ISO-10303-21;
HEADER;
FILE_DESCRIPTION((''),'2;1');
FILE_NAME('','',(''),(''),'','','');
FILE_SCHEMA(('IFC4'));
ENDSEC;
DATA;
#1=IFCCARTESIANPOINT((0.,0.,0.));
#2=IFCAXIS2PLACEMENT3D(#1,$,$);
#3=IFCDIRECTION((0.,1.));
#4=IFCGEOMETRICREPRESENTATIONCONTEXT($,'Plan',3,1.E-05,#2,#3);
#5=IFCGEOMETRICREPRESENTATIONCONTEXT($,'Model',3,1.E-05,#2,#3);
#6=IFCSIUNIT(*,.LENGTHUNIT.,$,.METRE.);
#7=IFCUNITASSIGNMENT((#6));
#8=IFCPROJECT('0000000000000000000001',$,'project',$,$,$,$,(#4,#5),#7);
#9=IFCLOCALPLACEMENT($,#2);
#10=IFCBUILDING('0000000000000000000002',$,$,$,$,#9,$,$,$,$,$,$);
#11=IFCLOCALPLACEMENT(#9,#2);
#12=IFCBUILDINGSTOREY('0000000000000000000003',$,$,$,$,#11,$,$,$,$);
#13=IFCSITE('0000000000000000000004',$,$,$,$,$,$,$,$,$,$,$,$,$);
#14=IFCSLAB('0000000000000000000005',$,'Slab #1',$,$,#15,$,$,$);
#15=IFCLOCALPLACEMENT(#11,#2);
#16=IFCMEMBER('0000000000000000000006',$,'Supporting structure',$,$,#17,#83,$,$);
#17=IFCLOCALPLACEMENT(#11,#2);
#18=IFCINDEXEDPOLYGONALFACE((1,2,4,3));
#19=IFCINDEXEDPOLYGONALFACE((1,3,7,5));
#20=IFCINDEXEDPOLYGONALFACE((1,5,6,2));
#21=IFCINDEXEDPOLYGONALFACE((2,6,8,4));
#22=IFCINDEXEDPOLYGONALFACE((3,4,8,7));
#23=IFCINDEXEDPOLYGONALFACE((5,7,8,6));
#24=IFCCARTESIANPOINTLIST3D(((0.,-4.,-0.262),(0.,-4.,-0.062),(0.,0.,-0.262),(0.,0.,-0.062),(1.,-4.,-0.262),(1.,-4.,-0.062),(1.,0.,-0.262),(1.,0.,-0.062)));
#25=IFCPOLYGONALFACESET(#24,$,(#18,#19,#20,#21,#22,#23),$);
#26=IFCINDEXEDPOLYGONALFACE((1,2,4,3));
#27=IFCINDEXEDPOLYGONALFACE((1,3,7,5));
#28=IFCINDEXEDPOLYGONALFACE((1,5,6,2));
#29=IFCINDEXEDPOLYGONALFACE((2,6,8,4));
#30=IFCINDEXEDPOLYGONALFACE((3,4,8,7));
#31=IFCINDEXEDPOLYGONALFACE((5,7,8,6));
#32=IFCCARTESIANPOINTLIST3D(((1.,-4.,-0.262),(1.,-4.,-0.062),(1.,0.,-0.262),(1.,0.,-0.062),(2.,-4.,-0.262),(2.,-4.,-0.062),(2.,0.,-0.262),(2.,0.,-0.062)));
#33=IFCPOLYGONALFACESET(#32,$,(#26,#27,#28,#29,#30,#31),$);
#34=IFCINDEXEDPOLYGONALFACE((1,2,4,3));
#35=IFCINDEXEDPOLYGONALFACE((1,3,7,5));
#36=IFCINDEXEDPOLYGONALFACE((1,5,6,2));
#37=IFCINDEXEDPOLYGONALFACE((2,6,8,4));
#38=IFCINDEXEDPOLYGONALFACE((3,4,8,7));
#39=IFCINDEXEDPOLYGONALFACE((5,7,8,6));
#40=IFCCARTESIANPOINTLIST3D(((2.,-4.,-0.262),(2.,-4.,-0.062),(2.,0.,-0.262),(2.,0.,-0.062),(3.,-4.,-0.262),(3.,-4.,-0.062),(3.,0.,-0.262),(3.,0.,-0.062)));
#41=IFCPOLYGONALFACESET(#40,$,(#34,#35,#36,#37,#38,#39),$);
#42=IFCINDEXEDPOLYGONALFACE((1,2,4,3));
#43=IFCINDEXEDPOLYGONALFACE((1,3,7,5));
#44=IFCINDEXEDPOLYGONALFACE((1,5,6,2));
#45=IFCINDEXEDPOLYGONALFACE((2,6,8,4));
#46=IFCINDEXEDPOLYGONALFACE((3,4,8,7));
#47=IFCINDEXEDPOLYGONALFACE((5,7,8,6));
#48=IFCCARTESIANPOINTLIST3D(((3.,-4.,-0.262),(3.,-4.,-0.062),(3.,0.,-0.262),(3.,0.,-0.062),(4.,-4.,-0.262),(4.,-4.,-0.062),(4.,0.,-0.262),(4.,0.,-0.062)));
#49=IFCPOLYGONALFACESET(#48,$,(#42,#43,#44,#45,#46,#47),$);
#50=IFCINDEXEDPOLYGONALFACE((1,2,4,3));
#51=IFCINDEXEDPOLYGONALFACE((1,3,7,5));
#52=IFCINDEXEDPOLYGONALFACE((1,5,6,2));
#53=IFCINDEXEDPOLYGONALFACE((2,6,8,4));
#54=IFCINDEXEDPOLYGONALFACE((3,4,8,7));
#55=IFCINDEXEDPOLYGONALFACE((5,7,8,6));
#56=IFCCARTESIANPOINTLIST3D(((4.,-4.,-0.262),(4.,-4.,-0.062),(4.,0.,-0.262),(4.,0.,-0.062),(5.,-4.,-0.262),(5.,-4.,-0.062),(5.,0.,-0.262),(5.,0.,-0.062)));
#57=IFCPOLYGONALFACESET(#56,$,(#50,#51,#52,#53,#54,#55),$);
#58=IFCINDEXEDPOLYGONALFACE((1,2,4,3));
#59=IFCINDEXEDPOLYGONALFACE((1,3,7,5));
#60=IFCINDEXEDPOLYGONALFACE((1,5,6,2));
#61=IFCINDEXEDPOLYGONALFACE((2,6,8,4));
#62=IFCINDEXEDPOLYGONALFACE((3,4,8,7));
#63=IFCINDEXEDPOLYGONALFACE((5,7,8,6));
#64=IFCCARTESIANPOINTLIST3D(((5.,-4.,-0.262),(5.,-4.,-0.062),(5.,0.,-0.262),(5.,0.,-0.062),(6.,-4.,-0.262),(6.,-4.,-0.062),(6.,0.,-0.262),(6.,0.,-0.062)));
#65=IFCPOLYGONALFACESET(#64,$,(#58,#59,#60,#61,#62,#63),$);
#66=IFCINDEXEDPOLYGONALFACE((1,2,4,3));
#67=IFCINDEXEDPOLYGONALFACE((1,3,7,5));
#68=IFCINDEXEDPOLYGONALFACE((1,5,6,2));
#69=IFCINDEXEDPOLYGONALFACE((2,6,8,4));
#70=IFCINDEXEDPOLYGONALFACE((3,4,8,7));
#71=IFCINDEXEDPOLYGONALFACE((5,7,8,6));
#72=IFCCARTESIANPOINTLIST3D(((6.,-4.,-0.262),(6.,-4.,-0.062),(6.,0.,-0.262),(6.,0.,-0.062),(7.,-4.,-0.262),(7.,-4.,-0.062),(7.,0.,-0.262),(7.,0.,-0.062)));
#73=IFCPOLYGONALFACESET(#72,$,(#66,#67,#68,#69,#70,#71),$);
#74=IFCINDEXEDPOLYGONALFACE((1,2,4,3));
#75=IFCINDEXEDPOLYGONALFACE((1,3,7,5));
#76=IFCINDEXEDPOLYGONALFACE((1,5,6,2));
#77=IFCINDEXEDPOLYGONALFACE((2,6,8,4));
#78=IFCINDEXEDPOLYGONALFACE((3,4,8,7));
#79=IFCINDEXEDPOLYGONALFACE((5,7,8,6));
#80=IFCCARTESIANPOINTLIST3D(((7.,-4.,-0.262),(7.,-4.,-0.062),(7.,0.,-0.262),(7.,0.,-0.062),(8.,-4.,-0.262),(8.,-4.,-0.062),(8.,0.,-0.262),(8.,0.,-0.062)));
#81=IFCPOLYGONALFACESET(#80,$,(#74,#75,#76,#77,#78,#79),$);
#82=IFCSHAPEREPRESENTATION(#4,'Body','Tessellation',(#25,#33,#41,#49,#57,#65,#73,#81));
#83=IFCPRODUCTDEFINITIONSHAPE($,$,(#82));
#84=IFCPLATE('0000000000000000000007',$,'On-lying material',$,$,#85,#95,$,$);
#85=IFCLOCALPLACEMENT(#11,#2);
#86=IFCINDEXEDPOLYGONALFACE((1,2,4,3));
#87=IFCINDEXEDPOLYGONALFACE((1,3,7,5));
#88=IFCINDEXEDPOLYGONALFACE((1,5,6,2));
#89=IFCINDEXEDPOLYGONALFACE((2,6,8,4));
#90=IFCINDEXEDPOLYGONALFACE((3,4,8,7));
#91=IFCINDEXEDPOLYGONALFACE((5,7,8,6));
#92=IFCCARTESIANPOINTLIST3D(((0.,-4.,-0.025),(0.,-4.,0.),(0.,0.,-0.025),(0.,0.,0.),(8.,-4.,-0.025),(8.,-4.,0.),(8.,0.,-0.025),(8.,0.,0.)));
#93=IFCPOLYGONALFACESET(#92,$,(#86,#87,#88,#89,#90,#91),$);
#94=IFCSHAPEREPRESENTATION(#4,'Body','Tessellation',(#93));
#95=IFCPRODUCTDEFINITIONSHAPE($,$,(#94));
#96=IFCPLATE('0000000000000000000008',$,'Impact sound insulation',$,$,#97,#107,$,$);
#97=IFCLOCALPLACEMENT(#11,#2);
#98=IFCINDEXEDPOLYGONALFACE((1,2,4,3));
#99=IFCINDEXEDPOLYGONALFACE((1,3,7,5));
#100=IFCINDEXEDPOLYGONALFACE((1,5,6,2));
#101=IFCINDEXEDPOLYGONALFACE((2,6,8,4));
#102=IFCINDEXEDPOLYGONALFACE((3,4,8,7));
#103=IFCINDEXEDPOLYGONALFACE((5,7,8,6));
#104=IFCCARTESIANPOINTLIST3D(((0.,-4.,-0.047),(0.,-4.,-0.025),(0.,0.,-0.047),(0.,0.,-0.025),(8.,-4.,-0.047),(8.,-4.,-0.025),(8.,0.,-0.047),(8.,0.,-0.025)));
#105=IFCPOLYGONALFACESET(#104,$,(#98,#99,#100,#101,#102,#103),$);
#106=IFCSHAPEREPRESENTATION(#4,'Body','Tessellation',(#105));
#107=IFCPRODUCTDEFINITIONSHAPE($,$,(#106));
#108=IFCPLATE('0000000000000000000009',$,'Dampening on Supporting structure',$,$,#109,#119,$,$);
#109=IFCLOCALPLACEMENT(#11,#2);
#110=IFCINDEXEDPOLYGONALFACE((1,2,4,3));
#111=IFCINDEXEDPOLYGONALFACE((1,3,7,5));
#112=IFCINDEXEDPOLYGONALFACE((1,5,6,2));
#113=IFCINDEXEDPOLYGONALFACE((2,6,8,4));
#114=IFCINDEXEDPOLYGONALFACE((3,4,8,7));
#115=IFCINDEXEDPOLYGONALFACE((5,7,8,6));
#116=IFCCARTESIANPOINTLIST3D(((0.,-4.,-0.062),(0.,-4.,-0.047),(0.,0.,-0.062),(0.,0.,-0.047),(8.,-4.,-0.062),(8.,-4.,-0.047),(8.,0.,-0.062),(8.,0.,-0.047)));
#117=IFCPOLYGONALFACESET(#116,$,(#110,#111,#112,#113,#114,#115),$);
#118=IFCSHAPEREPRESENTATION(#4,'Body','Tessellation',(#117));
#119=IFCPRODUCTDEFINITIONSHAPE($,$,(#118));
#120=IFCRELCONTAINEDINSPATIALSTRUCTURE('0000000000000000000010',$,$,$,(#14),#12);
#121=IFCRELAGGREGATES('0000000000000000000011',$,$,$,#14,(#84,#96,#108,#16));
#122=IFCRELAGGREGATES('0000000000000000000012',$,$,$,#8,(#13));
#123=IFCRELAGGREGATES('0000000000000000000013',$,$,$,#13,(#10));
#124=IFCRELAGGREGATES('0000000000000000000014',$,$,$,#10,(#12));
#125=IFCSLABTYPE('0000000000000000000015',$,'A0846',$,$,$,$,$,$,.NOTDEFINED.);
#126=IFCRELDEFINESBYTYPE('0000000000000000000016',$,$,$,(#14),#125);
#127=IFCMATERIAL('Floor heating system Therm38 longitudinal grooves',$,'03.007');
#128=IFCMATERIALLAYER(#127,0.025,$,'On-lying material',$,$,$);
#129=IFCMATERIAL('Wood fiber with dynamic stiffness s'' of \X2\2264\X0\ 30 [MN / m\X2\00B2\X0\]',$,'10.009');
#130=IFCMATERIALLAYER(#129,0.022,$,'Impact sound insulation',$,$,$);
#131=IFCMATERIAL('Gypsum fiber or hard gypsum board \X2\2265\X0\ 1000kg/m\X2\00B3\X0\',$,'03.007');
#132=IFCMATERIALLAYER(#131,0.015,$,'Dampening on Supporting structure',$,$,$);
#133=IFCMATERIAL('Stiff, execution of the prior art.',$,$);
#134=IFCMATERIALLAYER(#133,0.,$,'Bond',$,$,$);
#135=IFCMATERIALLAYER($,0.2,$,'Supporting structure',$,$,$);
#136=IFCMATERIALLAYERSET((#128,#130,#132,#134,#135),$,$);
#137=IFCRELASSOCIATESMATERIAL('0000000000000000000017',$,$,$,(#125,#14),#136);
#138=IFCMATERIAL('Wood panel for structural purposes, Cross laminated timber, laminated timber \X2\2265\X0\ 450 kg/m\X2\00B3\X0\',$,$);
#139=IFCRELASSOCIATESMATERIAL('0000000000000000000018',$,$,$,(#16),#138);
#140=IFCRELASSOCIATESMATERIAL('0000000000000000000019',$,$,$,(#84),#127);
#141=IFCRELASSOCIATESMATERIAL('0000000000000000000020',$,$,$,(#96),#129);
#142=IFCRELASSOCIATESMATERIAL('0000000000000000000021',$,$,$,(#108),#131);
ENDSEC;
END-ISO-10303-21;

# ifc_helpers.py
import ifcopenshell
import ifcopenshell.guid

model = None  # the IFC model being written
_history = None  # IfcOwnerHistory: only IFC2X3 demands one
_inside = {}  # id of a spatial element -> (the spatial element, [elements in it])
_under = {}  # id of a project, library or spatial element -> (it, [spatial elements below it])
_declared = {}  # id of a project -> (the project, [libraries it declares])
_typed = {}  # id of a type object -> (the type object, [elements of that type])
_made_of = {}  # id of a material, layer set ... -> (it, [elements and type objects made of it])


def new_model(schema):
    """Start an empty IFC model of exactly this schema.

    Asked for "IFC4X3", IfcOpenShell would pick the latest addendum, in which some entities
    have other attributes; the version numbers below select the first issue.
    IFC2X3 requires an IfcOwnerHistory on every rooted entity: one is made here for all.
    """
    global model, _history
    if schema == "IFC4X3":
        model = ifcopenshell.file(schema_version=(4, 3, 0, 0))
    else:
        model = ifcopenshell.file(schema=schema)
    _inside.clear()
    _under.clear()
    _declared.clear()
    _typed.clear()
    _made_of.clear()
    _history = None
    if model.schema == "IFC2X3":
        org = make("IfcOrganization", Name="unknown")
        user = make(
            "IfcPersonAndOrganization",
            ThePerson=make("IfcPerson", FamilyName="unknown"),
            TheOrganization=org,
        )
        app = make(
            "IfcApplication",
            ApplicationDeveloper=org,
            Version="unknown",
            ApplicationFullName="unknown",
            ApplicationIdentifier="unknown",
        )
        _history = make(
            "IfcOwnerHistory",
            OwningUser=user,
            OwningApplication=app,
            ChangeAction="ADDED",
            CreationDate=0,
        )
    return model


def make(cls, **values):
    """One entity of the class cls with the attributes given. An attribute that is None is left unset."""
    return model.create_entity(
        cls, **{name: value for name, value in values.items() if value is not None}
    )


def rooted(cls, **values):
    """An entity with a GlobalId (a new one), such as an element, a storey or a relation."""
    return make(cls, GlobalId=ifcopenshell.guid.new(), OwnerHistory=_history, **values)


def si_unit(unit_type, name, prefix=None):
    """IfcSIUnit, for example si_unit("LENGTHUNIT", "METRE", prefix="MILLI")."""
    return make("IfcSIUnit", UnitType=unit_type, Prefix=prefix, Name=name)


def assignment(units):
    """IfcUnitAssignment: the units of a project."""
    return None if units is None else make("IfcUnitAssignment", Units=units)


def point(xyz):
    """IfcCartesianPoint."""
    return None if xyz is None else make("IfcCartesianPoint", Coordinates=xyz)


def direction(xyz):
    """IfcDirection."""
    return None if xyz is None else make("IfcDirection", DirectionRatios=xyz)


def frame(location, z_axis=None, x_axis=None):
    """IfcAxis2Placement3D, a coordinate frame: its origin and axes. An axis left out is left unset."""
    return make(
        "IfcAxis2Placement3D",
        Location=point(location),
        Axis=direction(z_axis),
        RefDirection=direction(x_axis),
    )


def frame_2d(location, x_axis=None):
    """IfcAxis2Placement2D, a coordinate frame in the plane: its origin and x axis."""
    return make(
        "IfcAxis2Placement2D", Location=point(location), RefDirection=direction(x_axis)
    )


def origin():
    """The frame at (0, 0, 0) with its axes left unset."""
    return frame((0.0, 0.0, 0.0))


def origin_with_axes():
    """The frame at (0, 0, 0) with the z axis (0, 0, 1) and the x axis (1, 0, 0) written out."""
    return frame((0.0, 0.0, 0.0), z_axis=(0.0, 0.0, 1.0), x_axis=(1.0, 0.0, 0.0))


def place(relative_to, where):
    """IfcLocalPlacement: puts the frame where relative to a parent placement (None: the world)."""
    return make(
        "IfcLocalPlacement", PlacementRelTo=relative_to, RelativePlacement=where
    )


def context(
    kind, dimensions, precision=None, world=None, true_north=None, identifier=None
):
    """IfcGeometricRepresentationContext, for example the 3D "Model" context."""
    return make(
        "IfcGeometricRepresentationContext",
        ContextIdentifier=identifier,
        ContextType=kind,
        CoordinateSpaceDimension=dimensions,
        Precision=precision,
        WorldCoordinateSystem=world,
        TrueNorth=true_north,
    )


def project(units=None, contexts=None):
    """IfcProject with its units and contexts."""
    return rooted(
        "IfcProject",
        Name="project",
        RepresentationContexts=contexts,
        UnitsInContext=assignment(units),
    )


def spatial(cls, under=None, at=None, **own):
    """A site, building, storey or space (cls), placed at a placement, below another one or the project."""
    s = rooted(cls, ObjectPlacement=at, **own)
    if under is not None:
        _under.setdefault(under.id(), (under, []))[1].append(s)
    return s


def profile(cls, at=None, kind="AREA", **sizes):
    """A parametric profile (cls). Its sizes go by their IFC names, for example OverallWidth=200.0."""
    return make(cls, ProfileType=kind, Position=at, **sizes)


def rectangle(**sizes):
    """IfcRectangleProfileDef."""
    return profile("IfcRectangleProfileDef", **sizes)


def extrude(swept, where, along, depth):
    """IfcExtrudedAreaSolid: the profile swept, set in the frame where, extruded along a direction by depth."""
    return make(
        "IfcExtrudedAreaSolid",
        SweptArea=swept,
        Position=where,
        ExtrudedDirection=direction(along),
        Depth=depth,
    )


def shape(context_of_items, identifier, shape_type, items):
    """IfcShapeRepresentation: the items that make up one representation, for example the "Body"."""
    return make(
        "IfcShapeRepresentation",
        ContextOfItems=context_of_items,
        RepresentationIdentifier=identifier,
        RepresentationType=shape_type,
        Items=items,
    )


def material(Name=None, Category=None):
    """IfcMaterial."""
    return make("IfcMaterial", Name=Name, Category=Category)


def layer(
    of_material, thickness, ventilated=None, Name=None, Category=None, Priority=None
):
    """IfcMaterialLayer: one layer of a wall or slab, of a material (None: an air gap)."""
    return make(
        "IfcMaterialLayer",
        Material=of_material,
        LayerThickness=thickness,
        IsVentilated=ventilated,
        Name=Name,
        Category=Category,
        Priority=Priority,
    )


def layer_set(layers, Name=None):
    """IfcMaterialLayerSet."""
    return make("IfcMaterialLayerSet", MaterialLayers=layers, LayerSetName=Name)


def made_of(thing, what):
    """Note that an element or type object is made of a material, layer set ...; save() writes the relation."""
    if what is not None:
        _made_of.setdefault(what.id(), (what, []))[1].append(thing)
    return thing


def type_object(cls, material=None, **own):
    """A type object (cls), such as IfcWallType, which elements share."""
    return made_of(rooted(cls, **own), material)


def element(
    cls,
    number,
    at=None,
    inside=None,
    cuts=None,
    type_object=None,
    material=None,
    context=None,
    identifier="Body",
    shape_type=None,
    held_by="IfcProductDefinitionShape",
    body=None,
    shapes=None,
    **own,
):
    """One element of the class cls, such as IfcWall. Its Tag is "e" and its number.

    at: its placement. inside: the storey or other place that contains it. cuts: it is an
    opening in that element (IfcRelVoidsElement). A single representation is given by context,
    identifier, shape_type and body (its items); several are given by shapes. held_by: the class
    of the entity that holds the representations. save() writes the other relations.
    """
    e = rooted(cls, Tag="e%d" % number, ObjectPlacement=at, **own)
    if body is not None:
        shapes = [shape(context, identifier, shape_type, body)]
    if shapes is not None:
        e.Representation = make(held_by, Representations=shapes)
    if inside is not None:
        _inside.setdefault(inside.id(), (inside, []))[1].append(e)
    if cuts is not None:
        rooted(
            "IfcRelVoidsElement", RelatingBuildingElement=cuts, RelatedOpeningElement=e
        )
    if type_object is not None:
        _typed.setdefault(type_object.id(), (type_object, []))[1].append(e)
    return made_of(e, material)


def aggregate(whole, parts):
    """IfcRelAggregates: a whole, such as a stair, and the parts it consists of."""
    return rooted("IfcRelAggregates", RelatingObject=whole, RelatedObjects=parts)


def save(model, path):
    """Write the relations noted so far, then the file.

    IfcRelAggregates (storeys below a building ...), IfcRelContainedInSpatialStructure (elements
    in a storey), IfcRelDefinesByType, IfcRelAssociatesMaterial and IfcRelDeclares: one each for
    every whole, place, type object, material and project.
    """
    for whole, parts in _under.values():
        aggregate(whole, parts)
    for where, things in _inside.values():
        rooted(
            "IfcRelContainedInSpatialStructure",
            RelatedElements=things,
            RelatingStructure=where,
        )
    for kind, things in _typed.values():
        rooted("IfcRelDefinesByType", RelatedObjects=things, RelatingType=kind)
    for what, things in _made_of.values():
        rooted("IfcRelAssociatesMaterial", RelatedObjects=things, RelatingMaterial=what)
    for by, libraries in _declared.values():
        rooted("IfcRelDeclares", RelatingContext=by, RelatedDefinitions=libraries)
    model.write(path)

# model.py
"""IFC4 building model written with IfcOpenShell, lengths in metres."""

from ifc_helpers import new_model, si_unit, direction, frame, frame_2d, origin, origin_with_axes, place, context, project, spatial, rectangle, extrude, material, layer, layer_set, type_object, element, aggregate, save


model = new_model("IFC4")

# Units and contexts
plan_context = context("Plan", 3, precision=1e-05, world=origin(), true_north=direction((0.0, 1.0)))
model_context = context("Model", 3, precision=1e-05, world=origin(), true_north=direction((0.0, 1.0)))
ifc_project = project(units=[si_unit("LENGTHUNIT", "METRE")], contexts=[plan_context, model_context])

# Site, building, storey
site = spatial("IfcSite", under=ifc_project)
building_placement = place(None, origin())
building = spatial("IfcBuilding", under=site, at=building_placement)
storey_placement = place(building_placement, origin())
storey = spatial("IfcBuildingStorey", under=building, at=storey_placement)

# Slab, member, plates
ifc_material_1 = material(Name="Floor heating system Therm38 longitudinal grooves", Category="03.007")
ifc_layer_1 = layer(ifc_material_1, 0.025, Name="On-lying material")
ifc_material_2 = material(Name="Wood fiber with dynamic stiffness s' of ≤ 30 [MN / m²]", Category="10.009")
ifc_layer_2 = layer(ifc_material_2, 0.022, Name="Impact sound insulation")
ifc_material_3 = material(Name="Gypsum fiber or hard gypsum board ≥ 1000kg/m³", Category="03.007")
ifc_layer_3 = layer(ifc_material_3, 0.015, Name="Dampening on Supporting structure")
ifc_material_4 = material(Name="Stiff, execution of the prior art.")
ifc_layer_4 = layer(ifc_material_4, 0.0, Name="Bond")
ifc_layer_5 = layer(None, 0.2, Name="Supporting structure")
ifc_layer_set = layer_set([ifc_layer_1, ifc_layer_2, ifc_layer_3, ifc_layer_4, ifc_layer_5])
slab_type = type_object("IfcSlabType", Name="A0846", PredefinedType="NOTDEFINED", material=ifc_layer_set)
slab_placement = place(None, frame((0.0, 0.0, 0.0), z_axis=(0.0, 0.0, -1.0), x_axis=(1.0, 0.0, 0.0)))
slab = element("IfcSlab", 1, at=slab_placement, inside=storey, type_object=slab_type, material=ifc_layer_set, Name="Slab #1")
ifc_material_5 = material(Name="Wood panel for structural purposes, Cross laminated timber, laminated timber ≥ 450 kg/m³")
member_placement = place(slab_placement, origin())
member = element("IfcMember", 2, at=member_placement, material=ifc_material_5, Name="Supporting structure", context=plan_context, shape_type="SweptSolid", body=[
    extrude(rectangle(XDim=1.0, YDim=0.2, at=frame_2d((0.5, 0.1), x_axis=(1.0, 0.0))), frame((0.0, 4.0, 0.062), z_axis=(0.0, -1.0, 0.0), x_axis=(1.0, 0.0, 0.0)), (0.0, 0.0, 1.0), 4.0),
    extrude(rectangle(XDim=1.0, YDim=0.2, at=frame_2d((0.5, 0.1), x_axis=(1.0, 0.0))), frame((1.0, 4.0, 0.062), z_axis=(0.0, -1.0, 0.0), x_axis=(1.0, 0.0, 0.0)), (0.0, 0.0, 1.0), 4.0),
    extrude(rectangle(XDim=1.0, YDim=0.2, at=frame_2d((0.5, 0.1), x_axis=(1.0, 0.0))), frame((2.0, 4.0, 0.062), z_axis=(0.0, -1.0, 0.0), x_axis=(1.0, 0.0, 0.0)), (0.0, 0.0, 1.0), 4.0),
    extrude(rectangle(XDim=1.0, YDim=0.2, at=frame_2d((0.5, 0.1), x_axis=(1.0, 0.0))), frame((3.0, 4.0, 0.062), z_axis=(0.0, -1.0, 0.0), x_axis=(1.0, 0.0, 0.0)), (0.0, 0.0, 1.0), 4.0),
    extrude(rectangle(XDim=1.0, YDim=0.2, at=frame_2d((0.5, 0.1), x_axis=(1.0, 0.0))), frame((4.0, 4.0, 0.062), z_axis=(0.0, -1.0, 0.0), x_axis=(1.0, 0.0, 0.0)), (0.0, 0.0, 1.0), 4.0),
    extrude(rectangle(XDim=1.0, YDim=0.2, at=frame_2d((0.5, 0.1), x_axis=(1.0, 0.0))), frame((5.0, 4.0, 0.062), z_axis=(0.0, -1.0, 0.0), x_axis=(1.0, 0.0, 0.0)), (0.0, 0.0, 1.0), 4.0),
    extrude(rectangle(XDim=1.0, YDim=0.2, at=frame_2d((0.5, 0.1), x_axis=(1.0, 0.0))), frame((6.0, 4.0, 0.062), z_axis=(0.0, -1.0, 0.0), x_axis=(1.0, 0.0, 0.0)), (0.0, 0.0, 1.0), 4.0),
    extrude(rectangle(XDim=1.0, YDim=0.2, at=frame_2d((0.5, 0.1), x_axis=(1.0, 0.0))), frame((7.0, 4.0, 0.062), z_axis=(0.0, -1.0, 0.0), x_axis=(1.0, 0.0, 0.0)), (0.0, 0.0, 1.0), 4.0),
])
plate_1_placement = place(slab_placement, origin())
plate_1 = element("IfcPlate", 3, at=plate_1_placement, material=ifc_material_1, Name="On-lying material", context=plan_context, shape_type="SweptSolid", body=[
    extrude(rectangle(XDim=8.0, YDim=4.0, at=frame_2d((4.0, 2.0), x_axis=(1.0, 0.0))), origin_with_axes(), (0.0, 0.0, 1.0), 0.025),
])
plate_2_placement = place(slab_placement, origin())
plate_2 = element("IfcPlate", 4, at=plate_2_placement, material=ifc_material_2, Name="Impact sound insulation", context=plan_context, shape_type="SweptSolid", body=[
    extrude(rectangle(XDim=8.0, YDim=4.0, at=frame_2d((4.0, 2.0), x_axis=(1.0, 0.0))), frame((0.0, 0.0, 0.025), z_axis=(0.0, 0.0, 1.0), x_axis=(1.0, 0.0, 0.0)), (0.0, 0.0, 1.0), 0.022),
])
plate_3_placement = place(slab_placement, origin())
plate_3 = element("IfcPlate", 5, at=plate_3_placement, material=ifc_material_3, Name="Dampening on Supporting structure", context=plan_context, shape_type="SweptSolid", body=[
    extrude(rectangle(XDim=8.0, YDim=4.0, at=frame_2d((4.0, 2.0), x_axis=(1.0, 0.0))), frame((0.0, 0.0, 0.047), z_axis=(0.0, 0.0, 1.0), x_axis=(1.0, 0.0, 0.0)), (0.0, 0.0, 1.0), 0.015),
])
aggregate(slab, [plate_1, plate_2, plate_3, member])

save(model, "model.ifc")
